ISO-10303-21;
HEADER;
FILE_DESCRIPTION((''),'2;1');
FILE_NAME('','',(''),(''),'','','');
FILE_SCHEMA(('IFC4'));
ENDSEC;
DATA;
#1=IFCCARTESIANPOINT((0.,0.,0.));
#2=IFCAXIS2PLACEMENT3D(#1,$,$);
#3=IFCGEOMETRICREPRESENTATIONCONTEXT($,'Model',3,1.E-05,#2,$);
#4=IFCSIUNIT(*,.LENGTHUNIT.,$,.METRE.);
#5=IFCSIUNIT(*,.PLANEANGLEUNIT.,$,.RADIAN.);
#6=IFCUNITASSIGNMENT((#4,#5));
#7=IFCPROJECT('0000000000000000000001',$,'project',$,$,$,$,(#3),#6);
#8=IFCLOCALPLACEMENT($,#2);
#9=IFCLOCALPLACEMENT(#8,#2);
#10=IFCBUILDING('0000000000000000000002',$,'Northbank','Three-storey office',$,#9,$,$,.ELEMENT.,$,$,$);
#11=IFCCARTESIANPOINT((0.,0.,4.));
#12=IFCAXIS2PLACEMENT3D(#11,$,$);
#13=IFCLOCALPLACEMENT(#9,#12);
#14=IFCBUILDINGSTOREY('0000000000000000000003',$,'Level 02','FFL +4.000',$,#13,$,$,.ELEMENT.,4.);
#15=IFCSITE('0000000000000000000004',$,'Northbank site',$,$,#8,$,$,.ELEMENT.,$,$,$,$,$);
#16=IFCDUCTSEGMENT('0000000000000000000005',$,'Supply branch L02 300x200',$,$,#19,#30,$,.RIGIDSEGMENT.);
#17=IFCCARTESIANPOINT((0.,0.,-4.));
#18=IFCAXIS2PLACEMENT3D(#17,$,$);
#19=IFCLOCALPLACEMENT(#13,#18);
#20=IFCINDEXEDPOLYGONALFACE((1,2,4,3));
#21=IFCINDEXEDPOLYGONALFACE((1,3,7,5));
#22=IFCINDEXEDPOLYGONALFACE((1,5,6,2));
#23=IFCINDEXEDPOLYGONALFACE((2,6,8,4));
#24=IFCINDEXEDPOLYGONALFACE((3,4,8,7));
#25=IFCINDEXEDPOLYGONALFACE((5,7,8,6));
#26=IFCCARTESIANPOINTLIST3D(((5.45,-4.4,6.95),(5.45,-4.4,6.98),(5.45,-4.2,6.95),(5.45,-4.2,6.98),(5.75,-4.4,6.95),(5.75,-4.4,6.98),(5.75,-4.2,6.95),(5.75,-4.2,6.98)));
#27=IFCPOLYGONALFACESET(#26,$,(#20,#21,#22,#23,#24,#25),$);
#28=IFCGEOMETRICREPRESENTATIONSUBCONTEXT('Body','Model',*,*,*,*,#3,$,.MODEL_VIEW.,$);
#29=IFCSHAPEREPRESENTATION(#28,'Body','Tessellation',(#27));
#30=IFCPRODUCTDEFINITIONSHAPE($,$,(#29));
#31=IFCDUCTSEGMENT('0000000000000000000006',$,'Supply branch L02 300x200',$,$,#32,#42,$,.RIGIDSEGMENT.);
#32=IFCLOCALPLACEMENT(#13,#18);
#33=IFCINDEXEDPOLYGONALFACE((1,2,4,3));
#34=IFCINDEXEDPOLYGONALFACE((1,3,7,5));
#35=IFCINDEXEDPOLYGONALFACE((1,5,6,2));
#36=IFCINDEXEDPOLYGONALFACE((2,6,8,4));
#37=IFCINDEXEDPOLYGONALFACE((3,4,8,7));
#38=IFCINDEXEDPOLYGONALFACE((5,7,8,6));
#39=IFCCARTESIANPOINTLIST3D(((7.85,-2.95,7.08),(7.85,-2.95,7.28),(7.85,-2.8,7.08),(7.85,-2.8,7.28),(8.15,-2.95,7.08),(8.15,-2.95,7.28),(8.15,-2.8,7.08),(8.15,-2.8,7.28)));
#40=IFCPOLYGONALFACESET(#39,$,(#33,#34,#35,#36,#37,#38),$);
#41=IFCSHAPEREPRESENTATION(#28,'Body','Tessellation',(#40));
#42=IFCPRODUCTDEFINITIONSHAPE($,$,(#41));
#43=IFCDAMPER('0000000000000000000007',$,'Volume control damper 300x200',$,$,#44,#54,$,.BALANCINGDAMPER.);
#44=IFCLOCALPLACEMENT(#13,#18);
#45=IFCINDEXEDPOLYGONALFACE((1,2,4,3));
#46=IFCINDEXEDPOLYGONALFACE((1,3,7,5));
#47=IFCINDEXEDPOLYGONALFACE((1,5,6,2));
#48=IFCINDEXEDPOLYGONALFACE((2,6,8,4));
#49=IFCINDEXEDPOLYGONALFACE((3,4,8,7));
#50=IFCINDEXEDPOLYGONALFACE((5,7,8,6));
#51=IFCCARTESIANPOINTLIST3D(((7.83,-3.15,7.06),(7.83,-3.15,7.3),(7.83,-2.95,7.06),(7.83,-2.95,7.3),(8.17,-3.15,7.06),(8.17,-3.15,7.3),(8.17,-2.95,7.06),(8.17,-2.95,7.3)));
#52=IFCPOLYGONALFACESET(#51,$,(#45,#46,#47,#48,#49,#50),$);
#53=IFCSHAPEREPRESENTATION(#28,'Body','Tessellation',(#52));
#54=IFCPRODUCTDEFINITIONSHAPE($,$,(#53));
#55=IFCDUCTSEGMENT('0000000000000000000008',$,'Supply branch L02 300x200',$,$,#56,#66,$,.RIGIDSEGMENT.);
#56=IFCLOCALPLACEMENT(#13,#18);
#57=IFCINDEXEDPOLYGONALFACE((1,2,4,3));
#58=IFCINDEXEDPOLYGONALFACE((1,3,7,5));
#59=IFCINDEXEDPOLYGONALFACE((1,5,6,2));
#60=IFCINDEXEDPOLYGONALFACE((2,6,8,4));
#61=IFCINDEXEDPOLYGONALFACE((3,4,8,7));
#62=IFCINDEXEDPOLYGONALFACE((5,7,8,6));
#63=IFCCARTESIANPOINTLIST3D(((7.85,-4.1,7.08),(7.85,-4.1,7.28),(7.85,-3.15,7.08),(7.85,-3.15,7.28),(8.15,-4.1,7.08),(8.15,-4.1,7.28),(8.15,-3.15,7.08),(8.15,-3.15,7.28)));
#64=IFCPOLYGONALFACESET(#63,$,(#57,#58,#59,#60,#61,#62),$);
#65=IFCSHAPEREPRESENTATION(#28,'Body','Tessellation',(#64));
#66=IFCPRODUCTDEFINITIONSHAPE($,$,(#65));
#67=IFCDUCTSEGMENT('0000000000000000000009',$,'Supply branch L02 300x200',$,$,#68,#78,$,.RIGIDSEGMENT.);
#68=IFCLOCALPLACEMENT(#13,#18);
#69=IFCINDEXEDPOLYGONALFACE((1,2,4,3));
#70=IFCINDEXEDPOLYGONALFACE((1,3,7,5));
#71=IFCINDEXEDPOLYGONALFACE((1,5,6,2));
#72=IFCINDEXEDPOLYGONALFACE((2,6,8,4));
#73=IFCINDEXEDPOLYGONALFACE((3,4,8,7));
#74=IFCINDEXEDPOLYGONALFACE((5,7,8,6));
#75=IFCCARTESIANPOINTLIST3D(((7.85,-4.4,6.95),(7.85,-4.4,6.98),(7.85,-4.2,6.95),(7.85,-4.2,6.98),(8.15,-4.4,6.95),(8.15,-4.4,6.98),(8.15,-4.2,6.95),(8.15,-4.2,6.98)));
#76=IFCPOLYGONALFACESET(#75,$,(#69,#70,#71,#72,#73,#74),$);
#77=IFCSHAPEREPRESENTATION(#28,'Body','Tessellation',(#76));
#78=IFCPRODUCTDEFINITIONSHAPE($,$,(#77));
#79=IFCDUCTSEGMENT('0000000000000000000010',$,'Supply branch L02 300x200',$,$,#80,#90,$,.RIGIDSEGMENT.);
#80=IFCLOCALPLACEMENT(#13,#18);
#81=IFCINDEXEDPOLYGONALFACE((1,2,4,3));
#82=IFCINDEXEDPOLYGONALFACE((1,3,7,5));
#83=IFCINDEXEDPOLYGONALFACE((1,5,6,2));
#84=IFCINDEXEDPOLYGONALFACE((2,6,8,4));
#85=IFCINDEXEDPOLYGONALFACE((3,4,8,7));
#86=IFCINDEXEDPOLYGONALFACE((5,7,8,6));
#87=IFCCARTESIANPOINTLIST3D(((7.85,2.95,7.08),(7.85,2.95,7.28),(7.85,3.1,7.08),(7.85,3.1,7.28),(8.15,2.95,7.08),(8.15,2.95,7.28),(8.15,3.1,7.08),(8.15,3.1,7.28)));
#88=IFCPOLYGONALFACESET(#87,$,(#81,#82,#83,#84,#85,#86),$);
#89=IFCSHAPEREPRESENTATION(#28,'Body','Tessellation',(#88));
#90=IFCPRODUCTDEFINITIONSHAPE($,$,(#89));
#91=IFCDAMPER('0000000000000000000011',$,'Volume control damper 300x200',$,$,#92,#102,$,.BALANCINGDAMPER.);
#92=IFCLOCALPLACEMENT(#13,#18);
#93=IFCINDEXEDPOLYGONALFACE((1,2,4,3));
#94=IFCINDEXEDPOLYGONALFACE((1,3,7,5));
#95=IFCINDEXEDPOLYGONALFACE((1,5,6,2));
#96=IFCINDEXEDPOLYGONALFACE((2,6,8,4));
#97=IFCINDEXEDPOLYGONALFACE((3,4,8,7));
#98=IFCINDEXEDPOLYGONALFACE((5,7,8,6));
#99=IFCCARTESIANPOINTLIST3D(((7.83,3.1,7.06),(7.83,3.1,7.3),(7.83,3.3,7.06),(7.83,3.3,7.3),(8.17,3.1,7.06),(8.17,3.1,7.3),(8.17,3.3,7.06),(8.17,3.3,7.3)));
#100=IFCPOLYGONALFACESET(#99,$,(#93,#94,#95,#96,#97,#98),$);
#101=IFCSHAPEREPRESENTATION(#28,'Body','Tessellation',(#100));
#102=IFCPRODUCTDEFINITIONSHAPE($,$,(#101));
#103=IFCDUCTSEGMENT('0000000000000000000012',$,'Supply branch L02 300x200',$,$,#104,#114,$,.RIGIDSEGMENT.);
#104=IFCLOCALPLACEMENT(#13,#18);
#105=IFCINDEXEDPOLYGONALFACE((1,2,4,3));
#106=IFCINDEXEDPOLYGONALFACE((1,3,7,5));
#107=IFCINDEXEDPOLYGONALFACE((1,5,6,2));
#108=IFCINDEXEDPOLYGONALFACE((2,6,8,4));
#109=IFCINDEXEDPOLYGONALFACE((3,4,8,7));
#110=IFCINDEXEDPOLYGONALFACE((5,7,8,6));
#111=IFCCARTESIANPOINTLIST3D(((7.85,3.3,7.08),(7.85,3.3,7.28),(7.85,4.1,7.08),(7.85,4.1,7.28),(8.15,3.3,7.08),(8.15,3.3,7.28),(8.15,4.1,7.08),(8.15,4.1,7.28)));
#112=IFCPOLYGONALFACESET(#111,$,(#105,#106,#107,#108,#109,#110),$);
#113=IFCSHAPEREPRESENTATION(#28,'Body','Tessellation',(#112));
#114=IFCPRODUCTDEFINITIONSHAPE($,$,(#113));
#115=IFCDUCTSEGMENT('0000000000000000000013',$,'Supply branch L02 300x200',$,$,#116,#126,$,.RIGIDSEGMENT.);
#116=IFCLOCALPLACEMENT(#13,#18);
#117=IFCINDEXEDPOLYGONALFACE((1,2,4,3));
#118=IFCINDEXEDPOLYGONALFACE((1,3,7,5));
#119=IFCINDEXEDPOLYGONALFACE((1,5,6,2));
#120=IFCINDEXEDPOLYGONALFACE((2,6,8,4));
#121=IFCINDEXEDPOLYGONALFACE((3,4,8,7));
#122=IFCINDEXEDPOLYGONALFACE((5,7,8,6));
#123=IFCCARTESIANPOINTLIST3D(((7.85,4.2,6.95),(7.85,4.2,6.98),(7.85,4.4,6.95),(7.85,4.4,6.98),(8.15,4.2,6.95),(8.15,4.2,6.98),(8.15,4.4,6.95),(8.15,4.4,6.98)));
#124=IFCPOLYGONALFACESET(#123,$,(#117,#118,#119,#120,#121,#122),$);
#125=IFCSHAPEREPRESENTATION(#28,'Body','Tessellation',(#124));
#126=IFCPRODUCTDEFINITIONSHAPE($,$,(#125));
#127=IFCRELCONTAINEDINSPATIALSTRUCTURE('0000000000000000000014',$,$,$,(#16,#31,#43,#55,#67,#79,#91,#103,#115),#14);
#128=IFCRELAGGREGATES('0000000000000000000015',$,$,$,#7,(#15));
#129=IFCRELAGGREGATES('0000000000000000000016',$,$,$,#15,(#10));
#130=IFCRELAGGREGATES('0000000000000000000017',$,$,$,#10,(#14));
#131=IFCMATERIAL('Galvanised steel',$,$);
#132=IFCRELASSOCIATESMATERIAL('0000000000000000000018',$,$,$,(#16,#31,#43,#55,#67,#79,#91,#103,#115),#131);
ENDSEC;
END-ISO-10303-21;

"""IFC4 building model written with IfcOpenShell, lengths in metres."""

from ifc_helpers import new_model, si_unit, frame, origin, place, context, subcontext, project, spatial, rectangle, extrude, material, element, save


model = new_model("IFC4")

# Units and contexts
model_context = context("Model", 3, precision=1e-05, world=origin())
body_context = subcontext(model_context, "Body", "Model", "MODEL_VIEW")
ifc_project = project(units=[si_unit("LENGTHUNIT", "METRE"), si_unit("PLANEANGLEUNIT", "RADIAN")], contexts=[model_context])

# Site, building, storey
site_placement = place(None, origin())
site = spatial("IfcSite", under=ifc_project, at=site_placement, Name="Northbank site", CompositionType="ELEMENT")
building_placement = place(site_placement, origin())
building = spatial("IfcBuilding", under=site, at=building_placement, Name="Northbank", Description="Three-storey office", CompositionType="ELEMENT")
storey_placement = place(building_placement, frame((0.0, 0.0, 4.0)))
storey = spatial("IfcBuildingStorey", under=building, at=storey_placement, Name="Level 02", Description="FFL +4.000", CompositionType="ELEMENT", Elevation=4.0)

# Shared definitions
ifc_material_1 = material(Name="Galvanised steel")

# Duct segment
duct_segment_1_placement = place(storey_placement, frame((0.0, 0.0, -4.0)))
element("IfcDuctSegment", 1, at=duct_segment_1_placement, inside=storey, material=ifc_material_1, Name="Supply branch L02 300x200", PredefinedType="RIGIDSEGMENT", context=body_context, shape_type="SweptSolid", body=[
    extrude(rectangle(XDim=0.3, YDim=0.2), frame((5.6, -4.3, 6.98), z_axis=(0.0, 0.0, -1.0), x_axis=(1.0, 0.0, 0.0)), (0.0, 0.0, 1.0), 0.03),
])

# Duct segment
duct_segment_2_placement = place(storey_placement, frame((0.0, 0.0, -4.0)))
element("IfcDuctSegment", 2, at=duct_segment_2_placement, inside=storey, material=ifc_material_1, Name="Supply branch L02 300x200", PredefinedType="RIGIDSEGMENT", context=body_context, shape_type="SweptSolid", body=[
    extrude(rectangle(XDim=0.3, YDim=0.2), frame((8.0, -2.8, 7.18), z_axis=(0.0, -1.0, 0.0), x_axis=(1.0, 0.0, 0.0)), (0.0, 0.0, 1.0), 0.15),
])

# Damper
damper_1_placement = place(storey_placement, frame((0.0, 0.0, -4.0)))
element("IfcDamper", 3, at=damper_1_placement, inside=storey, material=ifc_material_1, Name="Volume control damper 300x200", PredefinedType="BALANCINGDAMPER", context=body_context, shape_type="SweptSolid", body=[
    extrude(rectangle(XDim=0.34, YDim=0.24), frame((8.0, -2.95, 7.18), z_axis=(0.0, -1.0, 0.0), x_axis=(1.0, 0.0, 0.0)), (0.0, 0.0, 1.0), 0.2),
])

# Duct segments
duct_segment_3_placement = place(storey_placement, frame((0.0, 0.0, -4.0)))
element("IfcDuctSegment", 4, at=duct_segment_3_placement, inside=storey, material=ifc_material_1, Name="Supply branch L02 300x200", PredefinedType="RIGIDSEGMENT", context=body_context, shape_type="SweptSolid", body=[
    extrude(rectangle(XDim=0.3, YDim=0.2), frame((8.0, -3.15, 7.18), z_axis=(0.0, -1.0, 0.0), x_axis=(1.0, 0.0, 0.0)), (0.0, 0.0, 1.0), 0.95),
])
duct_segment_4_placement = place(storey_placement, frame((0.0, 0.0, -4.0)))
element("IfcDuctSegment", 5, at=duct_segment_4_placement, inside=storey, material=ifc_material_1, Name="Supply branch L02 300x200", PredefinedType="RIGIDSEGMENT", context=body_context, shape_type="SweptSolid", body=[
    extrude(rectangle(XDim=0.3, YDim=0.2), frame((8.0, -4.3, 6.98), z_axis=(0.0, 0.0, -1.0), x_axis=(1.0, 0.0, 0.0)), (0.0, 0.0, 1.0), 0.03),
])

# Duct segment
duct_segment_5_placement = place(storey_placement, frame((0.0, 0.0, -4.0)))
element("IfcDuctSegment", 6, at=duct_segment_5_placement, inside=storey, material=ifc_material_1, Name="Supply branch L02 300x200", PredefinedType="RIGIDSEGMENT", context=body_context, shape_type="SweptSolid", body=[
    extrude(rectangle(XDim=0.3, YDim=0.2), frame((8.0, 2.95, 7.18), z_axis=(0.0, 1.0, 0.0), x_axis=(-1.0, 0.0, 0.0)), (0.0, 0.0, 1.0), 0.15),
])

# Damper
damper_2_placement = place(storey_placement, frame((0.0, 0.0, -4.0)))
element("IfcDamper", 7, at=damper_2_placement, inside=storey, material=ifc_material_1, Name="Volume control damper 300x200", PredefinedType="BALANCINGDAMPER", context=body_context, shape_type="SweptSolid", body=[
    extrude(rectangle(XDim=0.34, YDim=0.24), frame((8.0, 3.1, 7.18), z_axis=(0.0, 1.0, 0.0), x_axis=(-1.0, 0.0, 0.0)), (0.0, 0.0, 1.0), 0.2),
])

# Duct segments
duct_segment_6_placement = place(storey_placement, frame((0.0, 0.0, -4.0)))
element("IfcDuctSegment", 8, at=duct_segment_6_placement, inside=storey, material=ifc_material_1, Name="Supply branch L02 300x200", PredefinedType="RIGIDSEGMENT", context=body_context, shape_type="SweptSolid", body=[
    extrude(rectangle(XDim=0.3, YDim=0.2), frame((8.0, 3.3, 7.18), z_axis=(0.0, 1.0, 0.0), x_axis=(-1.0, 0.0, 0.0)), (0.0, 0.0, 1.0), 0.8),
])
duct_segment_7_placement = place(storey_placement, frame((0.0, 0.0, -4.0)))
element("IfcDuctSegment", 9, at=duct_segment_7_placement, inside=storey, material=ifc_material_1, Name="Supply branch L02 300x200", PredefinedType="RIGIDSEGMENT", context=body_context, shape_type="SweptSolid", body=[
    extrude(rectangle(XDim=0.3, YDim=0.2), frame((8.0, 4.3, 6.98), z_axis=(0.0, 0.0, -1.0), x_axis=(-1.0, 0.0, 0.0)), (0.0, 0.0, 1.0), 0.03),
])

save(model, "model.ifc")
